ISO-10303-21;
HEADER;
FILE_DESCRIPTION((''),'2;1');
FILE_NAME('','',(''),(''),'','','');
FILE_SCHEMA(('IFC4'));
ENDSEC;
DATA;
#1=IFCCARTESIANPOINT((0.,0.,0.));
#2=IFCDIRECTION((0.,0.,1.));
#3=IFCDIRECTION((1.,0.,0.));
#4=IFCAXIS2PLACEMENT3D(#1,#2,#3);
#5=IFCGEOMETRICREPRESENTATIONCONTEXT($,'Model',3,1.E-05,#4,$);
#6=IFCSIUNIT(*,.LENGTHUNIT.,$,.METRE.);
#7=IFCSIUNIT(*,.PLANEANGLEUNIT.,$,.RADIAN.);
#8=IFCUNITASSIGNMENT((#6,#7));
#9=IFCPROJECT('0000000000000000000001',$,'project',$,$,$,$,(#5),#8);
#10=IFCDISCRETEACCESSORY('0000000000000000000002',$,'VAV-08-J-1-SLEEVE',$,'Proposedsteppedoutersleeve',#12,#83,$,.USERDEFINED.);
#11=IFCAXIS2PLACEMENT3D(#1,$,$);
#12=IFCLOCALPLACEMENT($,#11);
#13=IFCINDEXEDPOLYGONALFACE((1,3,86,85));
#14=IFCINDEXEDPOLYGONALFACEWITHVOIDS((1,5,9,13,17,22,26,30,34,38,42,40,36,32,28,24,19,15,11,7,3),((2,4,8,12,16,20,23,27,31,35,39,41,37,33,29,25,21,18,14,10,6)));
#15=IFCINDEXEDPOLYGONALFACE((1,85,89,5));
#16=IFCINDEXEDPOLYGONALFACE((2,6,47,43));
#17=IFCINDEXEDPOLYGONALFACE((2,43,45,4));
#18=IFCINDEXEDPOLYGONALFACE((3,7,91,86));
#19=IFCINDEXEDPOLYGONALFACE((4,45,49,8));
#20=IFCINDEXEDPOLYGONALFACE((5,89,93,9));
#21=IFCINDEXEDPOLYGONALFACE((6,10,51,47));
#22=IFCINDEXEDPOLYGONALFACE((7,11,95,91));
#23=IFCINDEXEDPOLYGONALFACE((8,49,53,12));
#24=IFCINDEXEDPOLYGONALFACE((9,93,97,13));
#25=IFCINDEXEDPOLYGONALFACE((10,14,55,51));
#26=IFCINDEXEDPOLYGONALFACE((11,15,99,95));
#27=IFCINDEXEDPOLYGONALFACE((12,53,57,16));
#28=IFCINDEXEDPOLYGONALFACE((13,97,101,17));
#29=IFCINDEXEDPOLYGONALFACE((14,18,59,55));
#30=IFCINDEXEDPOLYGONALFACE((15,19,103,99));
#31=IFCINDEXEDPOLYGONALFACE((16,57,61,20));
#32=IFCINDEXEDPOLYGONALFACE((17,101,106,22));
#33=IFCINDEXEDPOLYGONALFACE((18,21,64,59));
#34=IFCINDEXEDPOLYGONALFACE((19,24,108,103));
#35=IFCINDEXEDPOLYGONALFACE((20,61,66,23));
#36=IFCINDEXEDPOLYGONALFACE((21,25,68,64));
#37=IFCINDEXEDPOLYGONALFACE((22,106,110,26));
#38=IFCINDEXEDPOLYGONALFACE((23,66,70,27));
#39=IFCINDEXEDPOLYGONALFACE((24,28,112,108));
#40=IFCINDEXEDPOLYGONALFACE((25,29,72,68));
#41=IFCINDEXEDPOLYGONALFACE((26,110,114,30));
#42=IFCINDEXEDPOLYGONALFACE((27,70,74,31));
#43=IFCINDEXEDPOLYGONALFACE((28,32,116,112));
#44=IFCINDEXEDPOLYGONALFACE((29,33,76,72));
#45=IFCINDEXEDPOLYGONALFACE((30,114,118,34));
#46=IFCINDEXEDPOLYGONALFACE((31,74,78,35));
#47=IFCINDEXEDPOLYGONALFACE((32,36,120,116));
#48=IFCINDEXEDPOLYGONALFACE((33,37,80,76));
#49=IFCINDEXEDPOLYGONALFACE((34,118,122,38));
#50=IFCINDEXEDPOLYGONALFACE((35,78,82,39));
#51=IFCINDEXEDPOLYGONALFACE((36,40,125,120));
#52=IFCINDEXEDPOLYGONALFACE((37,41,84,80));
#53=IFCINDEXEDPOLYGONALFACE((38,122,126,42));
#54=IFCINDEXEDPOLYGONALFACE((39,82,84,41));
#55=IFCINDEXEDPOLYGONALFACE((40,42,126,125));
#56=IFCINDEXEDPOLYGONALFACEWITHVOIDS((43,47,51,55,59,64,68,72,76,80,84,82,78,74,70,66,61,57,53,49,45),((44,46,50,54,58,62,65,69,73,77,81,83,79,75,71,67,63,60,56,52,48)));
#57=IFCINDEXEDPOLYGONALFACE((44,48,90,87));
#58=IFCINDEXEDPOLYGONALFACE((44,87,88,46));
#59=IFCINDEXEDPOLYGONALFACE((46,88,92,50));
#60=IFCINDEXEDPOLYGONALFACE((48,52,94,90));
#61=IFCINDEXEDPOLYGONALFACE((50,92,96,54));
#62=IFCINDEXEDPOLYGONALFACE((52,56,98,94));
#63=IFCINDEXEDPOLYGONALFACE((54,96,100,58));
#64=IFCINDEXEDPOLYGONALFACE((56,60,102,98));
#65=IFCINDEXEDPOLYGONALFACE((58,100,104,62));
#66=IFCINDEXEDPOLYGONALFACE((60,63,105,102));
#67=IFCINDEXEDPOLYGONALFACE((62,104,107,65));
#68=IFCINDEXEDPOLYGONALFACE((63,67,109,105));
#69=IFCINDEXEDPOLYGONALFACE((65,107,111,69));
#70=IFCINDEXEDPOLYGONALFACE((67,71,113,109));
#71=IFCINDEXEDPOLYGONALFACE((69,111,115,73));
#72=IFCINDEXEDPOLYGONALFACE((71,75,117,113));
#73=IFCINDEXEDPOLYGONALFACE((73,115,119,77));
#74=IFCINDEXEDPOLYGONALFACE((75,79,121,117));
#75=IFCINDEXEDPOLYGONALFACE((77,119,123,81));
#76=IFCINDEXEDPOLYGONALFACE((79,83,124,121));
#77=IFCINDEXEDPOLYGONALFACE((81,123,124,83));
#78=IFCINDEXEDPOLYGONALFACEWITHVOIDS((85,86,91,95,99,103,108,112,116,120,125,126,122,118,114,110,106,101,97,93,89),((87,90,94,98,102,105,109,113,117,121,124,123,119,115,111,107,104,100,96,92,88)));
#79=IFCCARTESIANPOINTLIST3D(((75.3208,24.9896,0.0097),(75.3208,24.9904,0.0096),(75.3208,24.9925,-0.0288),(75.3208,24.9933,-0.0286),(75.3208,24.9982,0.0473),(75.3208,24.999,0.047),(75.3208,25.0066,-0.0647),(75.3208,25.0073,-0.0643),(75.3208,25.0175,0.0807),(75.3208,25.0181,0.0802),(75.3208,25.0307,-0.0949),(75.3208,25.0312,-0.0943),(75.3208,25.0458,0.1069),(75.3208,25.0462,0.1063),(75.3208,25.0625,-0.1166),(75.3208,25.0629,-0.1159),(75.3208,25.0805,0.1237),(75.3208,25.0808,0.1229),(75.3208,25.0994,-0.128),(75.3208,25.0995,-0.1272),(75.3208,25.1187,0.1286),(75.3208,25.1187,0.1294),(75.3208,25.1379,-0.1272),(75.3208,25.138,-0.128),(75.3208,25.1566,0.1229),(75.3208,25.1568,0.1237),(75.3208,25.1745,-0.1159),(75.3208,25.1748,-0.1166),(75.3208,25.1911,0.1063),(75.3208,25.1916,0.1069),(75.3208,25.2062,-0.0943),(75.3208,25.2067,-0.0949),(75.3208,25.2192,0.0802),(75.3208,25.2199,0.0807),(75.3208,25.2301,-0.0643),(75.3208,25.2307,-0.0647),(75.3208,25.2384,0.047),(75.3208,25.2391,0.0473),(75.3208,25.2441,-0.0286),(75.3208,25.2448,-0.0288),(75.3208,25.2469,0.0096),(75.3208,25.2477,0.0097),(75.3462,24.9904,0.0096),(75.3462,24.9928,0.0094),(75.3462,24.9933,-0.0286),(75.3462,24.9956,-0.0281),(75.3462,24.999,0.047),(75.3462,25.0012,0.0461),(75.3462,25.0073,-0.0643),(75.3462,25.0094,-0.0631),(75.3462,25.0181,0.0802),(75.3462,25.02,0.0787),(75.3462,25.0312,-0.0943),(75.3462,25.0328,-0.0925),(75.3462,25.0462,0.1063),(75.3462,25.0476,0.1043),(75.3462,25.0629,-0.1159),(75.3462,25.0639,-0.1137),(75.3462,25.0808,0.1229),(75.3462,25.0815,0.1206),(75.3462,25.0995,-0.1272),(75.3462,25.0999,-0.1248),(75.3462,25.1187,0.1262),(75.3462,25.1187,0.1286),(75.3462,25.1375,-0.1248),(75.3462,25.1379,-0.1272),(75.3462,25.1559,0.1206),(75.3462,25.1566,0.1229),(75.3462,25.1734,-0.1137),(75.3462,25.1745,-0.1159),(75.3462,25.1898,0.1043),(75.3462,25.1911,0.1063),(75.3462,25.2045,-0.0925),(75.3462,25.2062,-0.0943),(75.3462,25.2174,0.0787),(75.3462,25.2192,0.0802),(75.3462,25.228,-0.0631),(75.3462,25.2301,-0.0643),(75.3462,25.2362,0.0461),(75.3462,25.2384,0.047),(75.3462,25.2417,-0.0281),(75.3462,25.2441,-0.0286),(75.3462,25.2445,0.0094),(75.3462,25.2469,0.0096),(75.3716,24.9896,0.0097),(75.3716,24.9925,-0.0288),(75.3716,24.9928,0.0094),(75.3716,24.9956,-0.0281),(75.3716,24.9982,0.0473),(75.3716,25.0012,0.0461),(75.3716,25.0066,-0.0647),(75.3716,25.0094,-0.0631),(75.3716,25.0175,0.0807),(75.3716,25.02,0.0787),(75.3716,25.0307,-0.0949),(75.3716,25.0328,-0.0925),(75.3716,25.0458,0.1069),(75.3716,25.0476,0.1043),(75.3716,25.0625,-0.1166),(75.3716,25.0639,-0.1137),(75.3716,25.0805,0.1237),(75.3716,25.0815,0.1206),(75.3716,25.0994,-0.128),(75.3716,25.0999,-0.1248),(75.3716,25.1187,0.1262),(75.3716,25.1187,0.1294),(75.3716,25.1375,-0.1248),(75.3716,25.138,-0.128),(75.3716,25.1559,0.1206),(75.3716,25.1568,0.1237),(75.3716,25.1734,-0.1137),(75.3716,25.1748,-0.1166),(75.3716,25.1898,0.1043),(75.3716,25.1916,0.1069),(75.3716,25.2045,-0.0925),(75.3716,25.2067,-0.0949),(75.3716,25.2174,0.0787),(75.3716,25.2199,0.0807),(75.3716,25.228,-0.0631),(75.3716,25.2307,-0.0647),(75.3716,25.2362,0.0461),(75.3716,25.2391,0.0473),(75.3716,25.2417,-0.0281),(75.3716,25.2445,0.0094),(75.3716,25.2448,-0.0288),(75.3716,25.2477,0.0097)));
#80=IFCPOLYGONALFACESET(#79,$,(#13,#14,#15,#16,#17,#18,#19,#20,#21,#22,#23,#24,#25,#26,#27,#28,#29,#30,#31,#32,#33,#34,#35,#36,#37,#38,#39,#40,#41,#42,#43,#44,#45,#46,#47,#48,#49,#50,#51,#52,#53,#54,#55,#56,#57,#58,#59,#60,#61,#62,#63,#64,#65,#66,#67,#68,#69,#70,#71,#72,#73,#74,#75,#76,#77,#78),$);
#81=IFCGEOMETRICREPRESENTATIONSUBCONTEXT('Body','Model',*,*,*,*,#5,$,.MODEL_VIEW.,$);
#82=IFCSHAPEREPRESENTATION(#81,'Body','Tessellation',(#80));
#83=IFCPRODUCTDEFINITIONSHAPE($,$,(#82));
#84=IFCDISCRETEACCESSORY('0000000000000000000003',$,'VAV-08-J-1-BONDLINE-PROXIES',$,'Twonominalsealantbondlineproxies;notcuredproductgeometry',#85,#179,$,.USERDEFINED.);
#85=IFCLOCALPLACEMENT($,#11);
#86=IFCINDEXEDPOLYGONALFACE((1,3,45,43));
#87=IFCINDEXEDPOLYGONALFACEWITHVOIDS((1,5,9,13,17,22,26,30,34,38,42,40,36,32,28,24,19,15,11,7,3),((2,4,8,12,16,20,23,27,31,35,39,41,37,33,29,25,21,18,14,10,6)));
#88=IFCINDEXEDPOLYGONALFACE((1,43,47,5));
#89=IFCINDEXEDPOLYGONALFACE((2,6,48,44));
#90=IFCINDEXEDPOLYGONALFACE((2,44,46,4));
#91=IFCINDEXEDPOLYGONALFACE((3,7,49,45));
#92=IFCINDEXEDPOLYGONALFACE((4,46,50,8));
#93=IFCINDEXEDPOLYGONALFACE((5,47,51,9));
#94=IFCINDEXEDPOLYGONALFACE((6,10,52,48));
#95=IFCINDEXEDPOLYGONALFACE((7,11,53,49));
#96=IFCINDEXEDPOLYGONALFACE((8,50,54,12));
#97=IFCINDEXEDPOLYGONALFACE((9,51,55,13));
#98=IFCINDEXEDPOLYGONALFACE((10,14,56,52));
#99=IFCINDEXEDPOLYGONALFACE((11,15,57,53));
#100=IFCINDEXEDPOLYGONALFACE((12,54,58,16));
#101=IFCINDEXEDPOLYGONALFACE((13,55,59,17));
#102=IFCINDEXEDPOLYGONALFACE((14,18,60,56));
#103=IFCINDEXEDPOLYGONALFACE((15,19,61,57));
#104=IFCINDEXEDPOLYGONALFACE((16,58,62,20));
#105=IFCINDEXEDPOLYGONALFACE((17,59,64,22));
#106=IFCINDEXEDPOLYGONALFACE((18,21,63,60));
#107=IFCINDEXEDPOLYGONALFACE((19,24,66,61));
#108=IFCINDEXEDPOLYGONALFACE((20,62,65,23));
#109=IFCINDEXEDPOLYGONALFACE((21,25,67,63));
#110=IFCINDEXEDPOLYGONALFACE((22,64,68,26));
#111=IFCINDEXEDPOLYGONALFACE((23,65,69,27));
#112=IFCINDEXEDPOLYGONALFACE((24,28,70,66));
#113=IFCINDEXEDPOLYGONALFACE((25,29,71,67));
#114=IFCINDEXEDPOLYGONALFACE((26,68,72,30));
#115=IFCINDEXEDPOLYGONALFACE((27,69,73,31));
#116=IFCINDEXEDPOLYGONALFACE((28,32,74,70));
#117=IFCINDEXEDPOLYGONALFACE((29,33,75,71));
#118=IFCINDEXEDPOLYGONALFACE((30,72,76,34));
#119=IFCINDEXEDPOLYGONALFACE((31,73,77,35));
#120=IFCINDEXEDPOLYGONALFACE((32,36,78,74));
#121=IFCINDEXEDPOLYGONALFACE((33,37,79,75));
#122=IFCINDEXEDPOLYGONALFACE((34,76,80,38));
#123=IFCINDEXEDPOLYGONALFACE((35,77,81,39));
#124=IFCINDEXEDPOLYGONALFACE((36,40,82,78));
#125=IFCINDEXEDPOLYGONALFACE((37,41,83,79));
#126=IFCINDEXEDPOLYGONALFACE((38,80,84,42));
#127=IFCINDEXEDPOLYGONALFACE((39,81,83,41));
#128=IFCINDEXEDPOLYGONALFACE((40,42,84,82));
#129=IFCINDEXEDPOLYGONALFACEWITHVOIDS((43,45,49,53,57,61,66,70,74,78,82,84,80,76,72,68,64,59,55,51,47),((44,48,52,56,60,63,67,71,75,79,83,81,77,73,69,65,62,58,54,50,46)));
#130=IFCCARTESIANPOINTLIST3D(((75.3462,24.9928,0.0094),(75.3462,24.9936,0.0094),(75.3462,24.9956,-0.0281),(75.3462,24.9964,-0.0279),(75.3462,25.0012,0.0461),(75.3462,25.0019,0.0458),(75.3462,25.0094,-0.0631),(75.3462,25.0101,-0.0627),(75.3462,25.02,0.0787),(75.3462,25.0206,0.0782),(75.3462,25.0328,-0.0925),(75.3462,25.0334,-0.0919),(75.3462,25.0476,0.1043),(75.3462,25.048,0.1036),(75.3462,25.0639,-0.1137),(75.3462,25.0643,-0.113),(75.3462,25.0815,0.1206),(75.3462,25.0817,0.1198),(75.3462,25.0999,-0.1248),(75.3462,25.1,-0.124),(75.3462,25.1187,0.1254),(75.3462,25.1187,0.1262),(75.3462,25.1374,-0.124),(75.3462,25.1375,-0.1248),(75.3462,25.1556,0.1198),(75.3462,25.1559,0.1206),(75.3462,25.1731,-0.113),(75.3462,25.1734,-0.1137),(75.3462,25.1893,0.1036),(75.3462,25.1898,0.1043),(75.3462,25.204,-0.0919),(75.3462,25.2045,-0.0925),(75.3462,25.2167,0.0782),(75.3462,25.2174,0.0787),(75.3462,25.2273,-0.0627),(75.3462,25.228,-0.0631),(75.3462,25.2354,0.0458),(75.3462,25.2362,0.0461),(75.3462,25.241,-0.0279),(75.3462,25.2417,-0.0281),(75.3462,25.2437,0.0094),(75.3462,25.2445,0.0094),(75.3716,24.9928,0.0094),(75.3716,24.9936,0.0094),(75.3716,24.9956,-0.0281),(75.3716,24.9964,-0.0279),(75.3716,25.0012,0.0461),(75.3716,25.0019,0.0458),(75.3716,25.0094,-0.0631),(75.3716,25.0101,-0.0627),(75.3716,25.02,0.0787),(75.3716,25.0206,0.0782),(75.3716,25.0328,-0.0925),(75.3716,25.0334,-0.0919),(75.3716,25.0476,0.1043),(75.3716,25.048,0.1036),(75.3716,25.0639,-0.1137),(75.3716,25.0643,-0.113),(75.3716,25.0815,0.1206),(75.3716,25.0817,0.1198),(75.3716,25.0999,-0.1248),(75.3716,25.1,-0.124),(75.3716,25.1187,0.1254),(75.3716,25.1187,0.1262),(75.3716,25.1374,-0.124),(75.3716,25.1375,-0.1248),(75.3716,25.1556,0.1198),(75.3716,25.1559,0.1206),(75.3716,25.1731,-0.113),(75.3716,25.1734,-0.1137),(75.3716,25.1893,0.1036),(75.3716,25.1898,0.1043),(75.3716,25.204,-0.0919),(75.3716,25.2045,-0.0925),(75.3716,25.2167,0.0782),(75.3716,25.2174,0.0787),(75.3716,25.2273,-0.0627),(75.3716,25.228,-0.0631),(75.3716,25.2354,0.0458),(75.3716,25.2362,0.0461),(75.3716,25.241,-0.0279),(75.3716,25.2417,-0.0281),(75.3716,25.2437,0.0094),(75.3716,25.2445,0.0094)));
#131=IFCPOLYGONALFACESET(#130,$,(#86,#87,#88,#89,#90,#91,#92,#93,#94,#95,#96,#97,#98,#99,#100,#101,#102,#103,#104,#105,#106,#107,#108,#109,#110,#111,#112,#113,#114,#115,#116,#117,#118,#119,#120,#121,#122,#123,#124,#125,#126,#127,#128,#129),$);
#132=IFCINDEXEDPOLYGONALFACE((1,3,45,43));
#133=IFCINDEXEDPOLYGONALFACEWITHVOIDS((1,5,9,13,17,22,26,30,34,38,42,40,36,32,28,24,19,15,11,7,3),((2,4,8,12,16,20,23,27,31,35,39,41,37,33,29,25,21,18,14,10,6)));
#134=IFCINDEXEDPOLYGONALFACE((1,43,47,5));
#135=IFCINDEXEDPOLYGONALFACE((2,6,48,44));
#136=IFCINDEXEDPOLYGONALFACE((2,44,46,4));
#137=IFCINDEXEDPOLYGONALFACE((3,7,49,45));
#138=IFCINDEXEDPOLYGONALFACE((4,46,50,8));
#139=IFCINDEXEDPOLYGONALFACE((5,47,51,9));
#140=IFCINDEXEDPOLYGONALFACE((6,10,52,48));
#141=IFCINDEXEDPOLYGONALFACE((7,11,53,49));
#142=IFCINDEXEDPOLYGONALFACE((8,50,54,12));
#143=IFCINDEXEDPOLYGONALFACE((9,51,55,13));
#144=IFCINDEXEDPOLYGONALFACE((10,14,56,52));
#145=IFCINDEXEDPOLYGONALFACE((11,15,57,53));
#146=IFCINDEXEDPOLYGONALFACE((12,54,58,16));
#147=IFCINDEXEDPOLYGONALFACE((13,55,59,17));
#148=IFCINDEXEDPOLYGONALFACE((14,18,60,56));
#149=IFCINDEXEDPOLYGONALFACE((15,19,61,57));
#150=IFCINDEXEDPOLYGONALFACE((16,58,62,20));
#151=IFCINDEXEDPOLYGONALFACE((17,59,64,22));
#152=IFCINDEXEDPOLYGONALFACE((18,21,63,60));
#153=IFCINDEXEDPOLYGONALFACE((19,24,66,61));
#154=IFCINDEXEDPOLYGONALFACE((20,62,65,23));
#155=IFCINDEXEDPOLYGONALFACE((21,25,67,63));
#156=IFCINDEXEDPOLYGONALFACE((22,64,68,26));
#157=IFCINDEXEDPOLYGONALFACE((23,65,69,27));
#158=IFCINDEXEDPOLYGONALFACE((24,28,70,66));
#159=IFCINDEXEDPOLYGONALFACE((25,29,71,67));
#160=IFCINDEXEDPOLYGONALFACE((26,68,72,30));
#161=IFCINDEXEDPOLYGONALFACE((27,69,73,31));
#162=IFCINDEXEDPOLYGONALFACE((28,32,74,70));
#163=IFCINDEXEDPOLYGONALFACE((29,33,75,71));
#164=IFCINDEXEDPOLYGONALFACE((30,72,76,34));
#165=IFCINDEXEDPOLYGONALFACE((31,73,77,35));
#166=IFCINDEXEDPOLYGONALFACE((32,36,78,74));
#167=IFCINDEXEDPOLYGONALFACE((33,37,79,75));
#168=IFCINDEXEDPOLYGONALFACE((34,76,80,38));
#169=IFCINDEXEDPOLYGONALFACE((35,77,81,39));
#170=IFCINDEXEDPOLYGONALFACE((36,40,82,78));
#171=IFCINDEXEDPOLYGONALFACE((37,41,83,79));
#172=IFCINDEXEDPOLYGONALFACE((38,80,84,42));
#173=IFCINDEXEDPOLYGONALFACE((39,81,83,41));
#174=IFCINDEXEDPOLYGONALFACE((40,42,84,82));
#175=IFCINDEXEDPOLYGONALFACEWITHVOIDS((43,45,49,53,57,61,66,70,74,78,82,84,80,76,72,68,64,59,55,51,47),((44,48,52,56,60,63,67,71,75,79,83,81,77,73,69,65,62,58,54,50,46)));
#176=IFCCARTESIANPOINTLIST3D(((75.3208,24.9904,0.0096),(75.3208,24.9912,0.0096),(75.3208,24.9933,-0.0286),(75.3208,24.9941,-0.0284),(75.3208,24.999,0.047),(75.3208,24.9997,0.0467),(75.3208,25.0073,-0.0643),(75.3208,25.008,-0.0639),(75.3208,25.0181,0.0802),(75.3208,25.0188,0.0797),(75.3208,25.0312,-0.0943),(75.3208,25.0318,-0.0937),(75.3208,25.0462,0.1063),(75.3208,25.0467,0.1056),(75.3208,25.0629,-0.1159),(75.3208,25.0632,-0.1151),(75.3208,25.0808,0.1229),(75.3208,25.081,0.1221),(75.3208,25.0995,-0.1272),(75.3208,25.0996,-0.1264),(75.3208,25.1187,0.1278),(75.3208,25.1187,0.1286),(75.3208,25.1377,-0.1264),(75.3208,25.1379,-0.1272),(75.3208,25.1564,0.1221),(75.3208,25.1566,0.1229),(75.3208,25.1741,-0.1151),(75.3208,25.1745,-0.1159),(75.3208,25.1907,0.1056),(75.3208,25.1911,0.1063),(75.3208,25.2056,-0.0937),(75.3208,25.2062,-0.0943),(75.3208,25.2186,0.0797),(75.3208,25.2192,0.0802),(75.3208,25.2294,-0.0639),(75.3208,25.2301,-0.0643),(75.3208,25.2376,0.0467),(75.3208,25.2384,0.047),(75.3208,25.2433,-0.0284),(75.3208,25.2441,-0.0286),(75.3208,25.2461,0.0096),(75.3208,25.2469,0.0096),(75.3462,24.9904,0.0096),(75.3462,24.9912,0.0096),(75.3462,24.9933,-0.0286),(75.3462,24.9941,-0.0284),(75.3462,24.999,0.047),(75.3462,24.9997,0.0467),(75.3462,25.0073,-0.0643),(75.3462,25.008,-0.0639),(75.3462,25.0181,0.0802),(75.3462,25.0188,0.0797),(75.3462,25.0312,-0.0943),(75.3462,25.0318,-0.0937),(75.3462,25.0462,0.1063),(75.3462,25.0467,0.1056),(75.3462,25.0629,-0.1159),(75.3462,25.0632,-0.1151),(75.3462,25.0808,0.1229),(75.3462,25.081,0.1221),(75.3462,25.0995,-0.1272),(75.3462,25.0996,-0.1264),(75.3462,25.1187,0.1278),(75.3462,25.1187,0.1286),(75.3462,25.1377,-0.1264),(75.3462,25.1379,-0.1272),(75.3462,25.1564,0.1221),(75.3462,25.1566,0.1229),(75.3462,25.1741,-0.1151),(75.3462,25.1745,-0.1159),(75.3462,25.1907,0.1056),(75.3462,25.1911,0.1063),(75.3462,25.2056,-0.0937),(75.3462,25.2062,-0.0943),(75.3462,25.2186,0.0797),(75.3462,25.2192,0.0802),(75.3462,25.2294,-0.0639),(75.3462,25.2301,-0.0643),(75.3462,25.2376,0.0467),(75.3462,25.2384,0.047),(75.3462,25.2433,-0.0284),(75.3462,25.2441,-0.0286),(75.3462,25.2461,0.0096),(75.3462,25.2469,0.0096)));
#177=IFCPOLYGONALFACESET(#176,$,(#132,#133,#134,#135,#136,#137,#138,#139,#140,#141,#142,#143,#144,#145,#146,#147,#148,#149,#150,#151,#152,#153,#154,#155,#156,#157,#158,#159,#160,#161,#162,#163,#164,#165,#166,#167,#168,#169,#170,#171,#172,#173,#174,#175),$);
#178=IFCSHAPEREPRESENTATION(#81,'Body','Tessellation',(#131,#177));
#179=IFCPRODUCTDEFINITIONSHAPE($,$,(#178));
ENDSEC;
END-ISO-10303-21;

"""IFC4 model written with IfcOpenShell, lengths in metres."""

from ifc_helpers import new_model, entity, si_unit, frame, origin_with_axes, place, context, subcontext, project, element, save


model = new_model("IFC4")

# Units and contexts
model_context = context("Model", 3, precision=1e-05, world=origin_with_axes())
body_context = subcontext(model_context, "Body", "Model", "MODEL_VIEW")
ifc_project = project(units=[si_unit("LENGTHUNIT", "METRE"), si_unit("PLANEANGLEUNIT", "RADIAN")], contexts=[model_context])

# Discrete accessories
discrete_accessory_1_placement = place(None, frame((75.3462, 25.1187, 0.0), z_axis=(0.0, -1.0, 0.0), x_axis=(0.0, 0.0, 1.0)))
element("IfcDiscreteAccessory", 1, at=discrete_accessory_1_placement, Name="VAV-08-J-1-SLEEVE", ObjectType="Proposedsteppedoutersleeve", PredefinedType="USERDEFINED", context=body_context, shape_type="SweptSolid", body=[
    entity("IfcRevolvedAreaSolid", entity("IfcArbitraryClosedProfileDef", "AREA", None, entity("IfcPolyline", [entity("IfcCartesianPoint", [0.1262, -0.0254]), entity("IfcCartesianPoint", [0.1294, -0.0254]), entity("IfcCartesianPoint", [0.1294, 0.0254]), entity("IfcCartesianPoint", [0.1286, 0.0254]), entity("IfcCartesianPoint", [0.1286, 0.0]), entity("IfcCartesianPoint", [0.1262, 0.0]), entity("IfcCartesianPoint", [0.1262, -0.0254])])), entity("IfcAxis2Placement3D", entity("IfcCartesianPoint", [0.0, 0.0, 0.0])), entity("IfcAxis1Placement", entity("IfcCartesianPoint", [0.0, 0.0, 0.0]), entity("IfcDirection", [0.0, 1.0, 0.0])), 6.283185),
])
discrete_accessory_2_placement = place(None, frame((75.3462, 25.1187, 0.0), z_axis=(0.0, -1.0, 0.0), x_axis=(0.0, 0.0, 1.0)))
element("IfcDiscreteAccessory", 2, at=discrete_accessory_2_placement, Name="VAV-08-J-1-BONDLINE-PROXIES", ObjectType="Twonominalsealantbondlineproxies;notcuredproductgeometry", PredefinedType="USERDEFINED", context=body_context, shape_type="SweptSolid", body=[
    entity("IfcRevolvedAreaSolid", entity("IfcArbitraryClosedProfileDef", "AREA", None, entity("IfcPolyline", [entity("IfcCartesianPoint", [0.1254, -0.0254]), entity("IfcCartesianPoint", [0.1262, -0.0254]), entity("IfcCartesianPoint", [0.1262, 0.0]), entity("IfcCartesianPoint", [0.1254, 0.0]), entity("IfcCartesianPoint", [0.1254, -0.0254])])), entity("IfcAxis2Placement3D", entity("IfcCartesianPoint", [0.0, 0.0, 0.0])), entity("IfcAxis1Placement", entity("IfcCartesianPoint", [0.0, 0.0, 0.0]), entity("IfcDirection", [0.0, 1.0, 0.0])), 6.283185),
    entity("IfcRevolvedAreaSolid", entity("IfcArbitraryClosedProfileDef", "AREA", None, entity("IfcPolyline", [entity("IfcCartesianPoint", [0.1278, 0.0]), entity("IfcCartesianPoint", [0.1286, 0.0]), entity("IfcCartesianPoint", [0.1286, 0.0254]), entity("IfcCartesianPoint", [0.1278, 0.0254]), entity("IfcCartesianPoint", [0.1278, 0.0])])), entity("IfcAxis2Placement3D", entity("IfcCartesianPoint", [0.0, 0.0, 0.0])), entity("IfcAxis1Placement", entity("IfcCartesianPoint", [0.0, 0.0, 0.0]), entity("IfcDirection", [0.0, 1.0, 0.0])), 6.283185),
])

save(model, "model.ifc")
